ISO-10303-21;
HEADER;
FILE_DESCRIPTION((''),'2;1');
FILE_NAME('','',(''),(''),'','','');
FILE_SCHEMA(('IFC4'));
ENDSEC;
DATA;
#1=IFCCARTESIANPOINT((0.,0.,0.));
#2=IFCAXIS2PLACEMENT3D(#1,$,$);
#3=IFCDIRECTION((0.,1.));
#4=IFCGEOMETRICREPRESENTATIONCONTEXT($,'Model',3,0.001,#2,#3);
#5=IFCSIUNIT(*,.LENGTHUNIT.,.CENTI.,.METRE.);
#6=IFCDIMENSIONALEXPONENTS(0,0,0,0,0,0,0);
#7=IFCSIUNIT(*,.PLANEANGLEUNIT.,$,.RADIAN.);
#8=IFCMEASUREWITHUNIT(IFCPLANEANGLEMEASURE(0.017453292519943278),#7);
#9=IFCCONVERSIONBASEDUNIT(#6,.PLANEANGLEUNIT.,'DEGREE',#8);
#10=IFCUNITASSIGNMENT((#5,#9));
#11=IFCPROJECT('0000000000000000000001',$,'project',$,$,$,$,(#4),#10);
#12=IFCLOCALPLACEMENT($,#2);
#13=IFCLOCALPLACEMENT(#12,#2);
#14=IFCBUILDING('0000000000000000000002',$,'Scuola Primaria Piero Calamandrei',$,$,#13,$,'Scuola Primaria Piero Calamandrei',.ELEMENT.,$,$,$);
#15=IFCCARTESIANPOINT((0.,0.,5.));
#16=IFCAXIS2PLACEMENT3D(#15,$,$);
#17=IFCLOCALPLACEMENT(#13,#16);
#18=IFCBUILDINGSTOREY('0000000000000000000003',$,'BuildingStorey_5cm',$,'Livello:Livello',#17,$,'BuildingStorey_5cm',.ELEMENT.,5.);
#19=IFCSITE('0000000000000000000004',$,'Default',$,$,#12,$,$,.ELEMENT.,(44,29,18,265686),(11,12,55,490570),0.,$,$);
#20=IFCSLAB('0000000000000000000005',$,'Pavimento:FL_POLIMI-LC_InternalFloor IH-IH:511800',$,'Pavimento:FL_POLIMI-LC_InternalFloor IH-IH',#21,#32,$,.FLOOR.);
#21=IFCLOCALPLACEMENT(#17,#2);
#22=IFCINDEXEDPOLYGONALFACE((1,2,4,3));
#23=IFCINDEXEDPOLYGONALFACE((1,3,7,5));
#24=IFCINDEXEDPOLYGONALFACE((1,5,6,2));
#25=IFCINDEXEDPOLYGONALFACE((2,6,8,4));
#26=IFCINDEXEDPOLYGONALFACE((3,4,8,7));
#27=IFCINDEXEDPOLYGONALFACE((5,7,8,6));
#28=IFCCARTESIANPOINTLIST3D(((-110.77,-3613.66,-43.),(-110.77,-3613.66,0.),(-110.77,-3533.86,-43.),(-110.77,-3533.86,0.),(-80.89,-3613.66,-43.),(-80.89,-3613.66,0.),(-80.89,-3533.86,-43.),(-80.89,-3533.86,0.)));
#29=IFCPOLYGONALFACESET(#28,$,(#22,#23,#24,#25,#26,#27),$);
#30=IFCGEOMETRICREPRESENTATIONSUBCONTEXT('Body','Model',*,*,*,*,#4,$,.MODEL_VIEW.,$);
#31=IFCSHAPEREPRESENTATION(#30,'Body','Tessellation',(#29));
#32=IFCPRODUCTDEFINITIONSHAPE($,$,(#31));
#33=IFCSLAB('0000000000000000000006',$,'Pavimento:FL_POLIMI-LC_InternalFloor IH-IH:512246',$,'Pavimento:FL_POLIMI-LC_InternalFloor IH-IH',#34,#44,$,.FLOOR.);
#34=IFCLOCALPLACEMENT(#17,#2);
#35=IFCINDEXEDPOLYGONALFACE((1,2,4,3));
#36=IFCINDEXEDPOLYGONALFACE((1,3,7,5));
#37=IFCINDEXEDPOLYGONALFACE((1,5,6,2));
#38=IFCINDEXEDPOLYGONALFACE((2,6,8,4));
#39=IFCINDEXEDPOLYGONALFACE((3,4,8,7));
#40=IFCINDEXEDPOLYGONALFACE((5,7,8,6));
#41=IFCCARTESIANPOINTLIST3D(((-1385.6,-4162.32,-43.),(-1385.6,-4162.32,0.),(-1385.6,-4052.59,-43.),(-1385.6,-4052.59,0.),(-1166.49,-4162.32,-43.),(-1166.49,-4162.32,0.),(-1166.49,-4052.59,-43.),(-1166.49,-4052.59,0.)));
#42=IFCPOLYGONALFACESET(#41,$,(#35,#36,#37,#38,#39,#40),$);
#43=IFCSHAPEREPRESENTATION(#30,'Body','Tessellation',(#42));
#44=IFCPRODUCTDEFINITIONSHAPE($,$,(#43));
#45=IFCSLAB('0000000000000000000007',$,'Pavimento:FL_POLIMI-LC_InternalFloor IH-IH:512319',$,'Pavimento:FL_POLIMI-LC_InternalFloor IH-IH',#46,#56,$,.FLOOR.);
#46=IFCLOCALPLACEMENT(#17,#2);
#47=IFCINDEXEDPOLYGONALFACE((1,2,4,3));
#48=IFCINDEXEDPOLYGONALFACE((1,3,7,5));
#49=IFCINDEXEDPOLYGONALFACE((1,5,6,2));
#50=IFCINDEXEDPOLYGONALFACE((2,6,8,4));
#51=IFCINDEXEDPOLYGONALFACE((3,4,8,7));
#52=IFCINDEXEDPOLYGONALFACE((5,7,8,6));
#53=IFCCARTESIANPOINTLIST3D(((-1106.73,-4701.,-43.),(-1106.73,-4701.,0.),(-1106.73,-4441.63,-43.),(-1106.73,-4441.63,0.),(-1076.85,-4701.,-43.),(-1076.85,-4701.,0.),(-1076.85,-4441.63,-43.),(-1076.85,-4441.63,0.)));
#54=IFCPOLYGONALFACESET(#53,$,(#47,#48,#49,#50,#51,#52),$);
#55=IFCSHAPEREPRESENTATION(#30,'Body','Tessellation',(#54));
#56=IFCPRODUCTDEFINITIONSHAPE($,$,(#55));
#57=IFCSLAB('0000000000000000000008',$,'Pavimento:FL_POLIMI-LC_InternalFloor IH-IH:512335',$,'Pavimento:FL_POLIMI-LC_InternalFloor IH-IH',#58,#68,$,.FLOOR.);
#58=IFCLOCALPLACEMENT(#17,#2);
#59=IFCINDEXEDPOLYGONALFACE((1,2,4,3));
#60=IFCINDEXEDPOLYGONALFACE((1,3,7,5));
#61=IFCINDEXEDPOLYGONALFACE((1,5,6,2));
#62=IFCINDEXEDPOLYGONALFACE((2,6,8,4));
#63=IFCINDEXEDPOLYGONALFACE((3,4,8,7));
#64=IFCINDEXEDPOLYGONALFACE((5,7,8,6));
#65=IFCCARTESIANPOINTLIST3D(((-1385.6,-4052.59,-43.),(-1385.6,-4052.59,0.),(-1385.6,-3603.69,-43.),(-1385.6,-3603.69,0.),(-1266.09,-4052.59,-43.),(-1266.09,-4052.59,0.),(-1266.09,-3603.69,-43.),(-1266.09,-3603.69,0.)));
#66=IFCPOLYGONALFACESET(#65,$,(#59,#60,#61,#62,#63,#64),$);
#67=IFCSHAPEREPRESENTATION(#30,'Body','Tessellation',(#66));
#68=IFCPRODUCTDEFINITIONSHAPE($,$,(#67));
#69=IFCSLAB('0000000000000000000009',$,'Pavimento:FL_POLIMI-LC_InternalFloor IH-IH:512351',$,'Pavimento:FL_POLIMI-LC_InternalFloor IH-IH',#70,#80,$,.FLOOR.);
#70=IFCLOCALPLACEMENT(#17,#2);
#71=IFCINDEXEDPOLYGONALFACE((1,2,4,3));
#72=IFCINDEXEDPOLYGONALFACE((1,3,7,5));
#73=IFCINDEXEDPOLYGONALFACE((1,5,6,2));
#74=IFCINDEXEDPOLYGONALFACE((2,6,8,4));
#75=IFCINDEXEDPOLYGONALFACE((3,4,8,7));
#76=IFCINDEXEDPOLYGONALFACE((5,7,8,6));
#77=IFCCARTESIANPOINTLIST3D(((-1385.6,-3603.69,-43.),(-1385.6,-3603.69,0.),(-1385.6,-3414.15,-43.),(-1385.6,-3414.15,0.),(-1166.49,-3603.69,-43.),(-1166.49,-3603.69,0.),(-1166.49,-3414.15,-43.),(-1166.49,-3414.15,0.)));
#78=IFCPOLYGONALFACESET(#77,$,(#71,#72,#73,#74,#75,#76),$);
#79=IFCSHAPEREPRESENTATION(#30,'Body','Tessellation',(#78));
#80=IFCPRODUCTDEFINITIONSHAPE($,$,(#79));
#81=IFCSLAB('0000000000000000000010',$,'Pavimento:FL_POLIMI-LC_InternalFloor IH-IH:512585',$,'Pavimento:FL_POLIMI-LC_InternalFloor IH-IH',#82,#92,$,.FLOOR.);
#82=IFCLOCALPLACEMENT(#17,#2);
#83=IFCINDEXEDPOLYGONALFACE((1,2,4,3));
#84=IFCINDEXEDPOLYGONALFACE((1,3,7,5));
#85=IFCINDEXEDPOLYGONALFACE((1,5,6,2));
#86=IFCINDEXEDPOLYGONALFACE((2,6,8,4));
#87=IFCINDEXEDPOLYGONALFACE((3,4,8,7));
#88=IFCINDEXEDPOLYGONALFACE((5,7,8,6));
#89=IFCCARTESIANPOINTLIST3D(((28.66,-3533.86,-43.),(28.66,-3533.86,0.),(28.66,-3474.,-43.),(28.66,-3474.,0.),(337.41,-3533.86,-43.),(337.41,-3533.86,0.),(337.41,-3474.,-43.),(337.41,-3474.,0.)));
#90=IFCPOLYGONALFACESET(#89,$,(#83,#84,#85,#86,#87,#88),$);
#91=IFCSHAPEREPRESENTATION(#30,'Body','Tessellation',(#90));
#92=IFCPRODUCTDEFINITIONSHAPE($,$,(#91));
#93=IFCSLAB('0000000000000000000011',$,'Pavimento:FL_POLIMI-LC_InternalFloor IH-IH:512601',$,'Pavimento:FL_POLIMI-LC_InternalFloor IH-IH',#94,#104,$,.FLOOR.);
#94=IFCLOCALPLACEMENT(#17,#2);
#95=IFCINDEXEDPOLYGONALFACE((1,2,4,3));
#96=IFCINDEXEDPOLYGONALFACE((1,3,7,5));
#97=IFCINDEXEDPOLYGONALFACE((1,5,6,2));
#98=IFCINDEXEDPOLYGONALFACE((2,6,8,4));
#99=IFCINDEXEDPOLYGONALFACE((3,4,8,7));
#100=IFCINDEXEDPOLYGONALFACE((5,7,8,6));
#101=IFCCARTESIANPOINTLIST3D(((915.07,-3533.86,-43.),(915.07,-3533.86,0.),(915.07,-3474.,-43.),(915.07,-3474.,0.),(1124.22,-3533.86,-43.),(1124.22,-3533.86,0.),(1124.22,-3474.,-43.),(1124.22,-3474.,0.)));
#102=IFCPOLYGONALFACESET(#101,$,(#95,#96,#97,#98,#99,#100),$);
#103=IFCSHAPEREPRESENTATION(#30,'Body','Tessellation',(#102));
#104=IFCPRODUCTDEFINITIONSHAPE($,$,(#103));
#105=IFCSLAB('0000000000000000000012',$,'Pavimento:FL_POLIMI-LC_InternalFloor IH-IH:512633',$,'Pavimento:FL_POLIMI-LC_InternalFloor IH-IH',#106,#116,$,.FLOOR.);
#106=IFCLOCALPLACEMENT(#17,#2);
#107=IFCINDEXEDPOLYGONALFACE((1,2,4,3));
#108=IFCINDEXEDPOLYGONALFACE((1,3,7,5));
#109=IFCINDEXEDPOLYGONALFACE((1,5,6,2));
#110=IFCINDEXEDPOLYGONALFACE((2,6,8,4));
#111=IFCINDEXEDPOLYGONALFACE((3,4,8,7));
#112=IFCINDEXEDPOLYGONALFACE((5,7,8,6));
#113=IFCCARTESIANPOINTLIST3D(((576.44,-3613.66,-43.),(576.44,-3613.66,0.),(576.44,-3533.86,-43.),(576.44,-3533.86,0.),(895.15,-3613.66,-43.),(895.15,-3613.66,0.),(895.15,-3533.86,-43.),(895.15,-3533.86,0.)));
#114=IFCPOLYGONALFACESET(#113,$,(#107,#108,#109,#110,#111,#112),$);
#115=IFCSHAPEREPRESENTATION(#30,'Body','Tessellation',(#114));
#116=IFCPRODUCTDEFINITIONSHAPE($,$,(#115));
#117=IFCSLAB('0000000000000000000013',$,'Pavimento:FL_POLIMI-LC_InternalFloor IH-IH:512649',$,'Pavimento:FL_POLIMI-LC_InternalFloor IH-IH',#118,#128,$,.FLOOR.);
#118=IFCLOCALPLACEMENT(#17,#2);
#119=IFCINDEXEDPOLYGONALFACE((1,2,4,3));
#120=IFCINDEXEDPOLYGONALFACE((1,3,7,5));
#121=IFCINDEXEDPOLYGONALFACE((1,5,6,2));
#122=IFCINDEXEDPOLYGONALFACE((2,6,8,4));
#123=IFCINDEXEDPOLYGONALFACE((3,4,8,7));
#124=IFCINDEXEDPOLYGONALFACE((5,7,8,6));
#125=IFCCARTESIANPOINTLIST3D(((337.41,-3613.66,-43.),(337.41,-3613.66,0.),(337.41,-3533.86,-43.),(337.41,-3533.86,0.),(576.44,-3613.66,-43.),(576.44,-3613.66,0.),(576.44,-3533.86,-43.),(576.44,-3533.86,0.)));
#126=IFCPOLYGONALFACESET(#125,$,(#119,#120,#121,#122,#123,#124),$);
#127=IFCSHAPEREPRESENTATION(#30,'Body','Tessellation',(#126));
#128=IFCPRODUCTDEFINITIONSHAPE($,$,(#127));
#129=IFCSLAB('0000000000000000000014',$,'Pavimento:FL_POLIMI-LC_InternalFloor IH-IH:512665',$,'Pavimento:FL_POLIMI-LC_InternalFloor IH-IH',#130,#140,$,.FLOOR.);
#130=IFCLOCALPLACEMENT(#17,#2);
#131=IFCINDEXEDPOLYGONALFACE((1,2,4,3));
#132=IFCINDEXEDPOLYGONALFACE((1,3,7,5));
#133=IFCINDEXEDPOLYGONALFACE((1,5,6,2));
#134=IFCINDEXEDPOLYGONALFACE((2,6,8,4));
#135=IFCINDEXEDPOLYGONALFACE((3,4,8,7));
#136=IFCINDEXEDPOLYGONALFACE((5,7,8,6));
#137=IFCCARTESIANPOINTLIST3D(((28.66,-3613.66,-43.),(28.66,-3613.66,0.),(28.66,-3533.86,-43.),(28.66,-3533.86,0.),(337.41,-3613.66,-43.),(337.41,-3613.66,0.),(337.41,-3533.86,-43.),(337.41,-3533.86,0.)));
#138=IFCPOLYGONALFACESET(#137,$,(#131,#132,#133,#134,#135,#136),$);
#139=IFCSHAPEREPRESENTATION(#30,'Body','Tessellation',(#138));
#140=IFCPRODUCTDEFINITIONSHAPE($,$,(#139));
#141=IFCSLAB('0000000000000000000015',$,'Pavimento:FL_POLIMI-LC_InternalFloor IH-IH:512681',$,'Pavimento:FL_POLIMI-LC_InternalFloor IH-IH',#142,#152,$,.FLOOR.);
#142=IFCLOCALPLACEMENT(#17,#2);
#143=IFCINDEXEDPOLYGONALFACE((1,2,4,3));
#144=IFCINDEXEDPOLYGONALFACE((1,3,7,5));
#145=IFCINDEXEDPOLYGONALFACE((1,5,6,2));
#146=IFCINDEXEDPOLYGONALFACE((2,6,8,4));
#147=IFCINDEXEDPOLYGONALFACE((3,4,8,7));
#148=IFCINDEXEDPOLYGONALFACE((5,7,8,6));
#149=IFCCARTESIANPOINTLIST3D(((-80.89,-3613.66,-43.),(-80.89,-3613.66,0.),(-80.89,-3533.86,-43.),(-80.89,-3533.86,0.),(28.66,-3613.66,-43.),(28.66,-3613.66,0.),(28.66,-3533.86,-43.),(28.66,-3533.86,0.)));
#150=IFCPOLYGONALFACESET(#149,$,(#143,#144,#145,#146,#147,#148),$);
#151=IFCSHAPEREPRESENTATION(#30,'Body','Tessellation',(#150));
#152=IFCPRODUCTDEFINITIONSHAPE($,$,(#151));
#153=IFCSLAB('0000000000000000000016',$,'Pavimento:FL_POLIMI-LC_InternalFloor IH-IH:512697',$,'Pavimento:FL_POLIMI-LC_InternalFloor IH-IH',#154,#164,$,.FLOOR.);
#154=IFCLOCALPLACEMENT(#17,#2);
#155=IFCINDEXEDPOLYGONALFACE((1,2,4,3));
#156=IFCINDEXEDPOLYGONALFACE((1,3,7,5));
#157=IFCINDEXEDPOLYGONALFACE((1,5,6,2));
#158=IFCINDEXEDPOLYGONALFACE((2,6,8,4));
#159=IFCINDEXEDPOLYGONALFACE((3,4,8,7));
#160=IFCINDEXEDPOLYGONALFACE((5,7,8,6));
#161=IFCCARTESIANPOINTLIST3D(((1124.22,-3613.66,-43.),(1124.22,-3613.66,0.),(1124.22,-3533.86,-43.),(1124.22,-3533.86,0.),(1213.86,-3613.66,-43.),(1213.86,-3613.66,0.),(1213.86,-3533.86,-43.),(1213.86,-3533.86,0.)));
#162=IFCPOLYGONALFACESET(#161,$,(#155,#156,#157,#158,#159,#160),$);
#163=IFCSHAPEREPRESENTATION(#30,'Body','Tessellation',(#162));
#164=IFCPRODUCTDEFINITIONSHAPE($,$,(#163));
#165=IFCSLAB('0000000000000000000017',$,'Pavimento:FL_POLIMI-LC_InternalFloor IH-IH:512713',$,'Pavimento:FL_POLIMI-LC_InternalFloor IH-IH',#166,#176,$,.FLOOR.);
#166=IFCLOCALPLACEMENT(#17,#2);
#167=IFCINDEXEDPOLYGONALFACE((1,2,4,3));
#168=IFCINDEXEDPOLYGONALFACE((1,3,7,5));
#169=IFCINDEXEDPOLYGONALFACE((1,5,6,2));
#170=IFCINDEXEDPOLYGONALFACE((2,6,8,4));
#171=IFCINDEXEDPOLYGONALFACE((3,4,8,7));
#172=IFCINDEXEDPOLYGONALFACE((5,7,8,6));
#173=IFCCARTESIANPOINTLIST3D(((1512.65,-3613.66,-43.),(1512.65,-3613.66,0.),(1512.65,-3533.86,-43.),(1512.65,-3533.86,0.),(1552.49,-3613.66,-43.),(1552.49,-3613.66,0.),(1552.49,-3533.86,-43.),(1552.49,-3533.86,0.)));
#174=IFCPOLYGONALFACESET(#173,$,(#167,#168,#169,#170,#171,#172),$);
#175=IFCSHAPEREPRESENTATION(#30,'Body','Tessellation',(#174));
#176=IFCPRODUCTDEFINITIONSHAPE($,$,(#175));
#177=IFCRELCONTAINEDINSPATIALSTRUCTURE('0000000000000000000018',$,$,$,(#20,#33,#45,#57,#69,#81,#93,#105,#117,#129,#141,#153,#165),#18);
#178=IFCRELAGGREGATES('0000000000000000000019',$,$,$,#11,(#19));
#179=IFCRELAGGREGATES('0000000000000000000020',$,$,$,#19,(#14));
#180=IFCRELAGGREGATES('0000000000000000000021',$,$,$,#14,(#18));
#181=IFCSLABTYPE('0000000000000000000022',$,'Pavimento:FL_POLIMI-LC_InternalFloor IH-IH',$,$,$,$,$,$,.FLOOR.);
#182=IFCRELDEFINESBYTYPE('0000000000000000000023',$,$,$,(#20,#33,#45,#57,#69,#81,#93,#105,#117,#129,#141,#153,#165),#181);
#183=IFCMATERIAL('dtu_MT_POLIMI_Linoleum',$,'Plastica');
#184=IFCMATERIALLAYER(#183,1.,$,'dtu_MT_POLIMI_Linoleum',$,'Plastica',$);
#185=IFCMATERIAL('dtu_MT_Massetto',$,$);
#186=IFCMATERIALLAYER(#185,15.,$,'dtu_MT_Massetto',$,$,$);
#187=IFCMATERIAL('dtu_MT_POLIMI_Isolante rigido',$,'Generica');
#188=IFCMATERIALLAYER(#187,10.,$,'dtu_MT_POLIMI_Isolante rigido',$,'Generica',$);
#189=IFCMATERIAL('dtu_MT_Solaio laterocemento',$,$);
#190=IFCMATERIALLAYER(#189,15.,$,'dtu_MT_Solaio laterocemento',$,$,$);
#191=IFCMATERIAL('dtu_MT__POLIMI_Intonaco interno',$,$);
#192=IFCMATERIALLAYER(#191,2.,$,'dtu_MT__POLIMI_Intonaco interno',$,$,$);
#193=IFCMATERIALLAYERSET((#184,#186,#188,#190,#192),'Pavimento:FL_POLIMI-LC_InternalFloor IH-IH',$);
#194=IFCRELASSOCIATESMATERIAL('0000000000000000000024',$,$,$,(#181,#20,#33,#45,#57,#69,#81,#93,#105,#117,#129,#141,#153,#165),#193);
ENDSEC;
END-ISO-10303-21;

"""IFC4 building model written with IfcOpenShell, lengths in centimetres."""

from ifc_helpers import new_model, entity, si_unit, converted_unit, direction, frame, frame_2d, origin, origin_2d_with_axis, place, context, subcontext, project, spatial, rectangle, extrude, material, layer, layer_set, layer_usage, type_object, element, save


model = new_model("IFC4")

# Units and contexts
model_context = context("Model", 3, precision=0.001, world=origin(), true_north=direction((0.0, 1.0)))
body_context = subcontext(model_context, "Body", "Model", "MODEL_VIEW")
ifc_project = project(units=[si_unit("LENGTHUNIT", "METRE", prefix="CENTI"), converted_unit("PLANEANGLEUNIT", "DEGREE", entity("IfcPlaneAngleMeasure", 0.017453292519943278), si_unit("PLANEANGLEUNIT", "RADIAN"), dimensions=[0, 0, 0, 0, 0, 0, 0])], contexts=[model_context])

# Site, building, storey
site_placement = place(None, origin())
site = spatial("IfcSite", under=ifc_project, at=site_placement, Name="Default", CompositionType="ELEMENT", RefLatitude=(44, 29, 18, 265686), RefLongitude=(11, 12, 55, 490570), RefElevation=0.0)
building_placement = place(site_placement, origin())
building = spatial("IfcBuilding", under=site, at=building_placement, Name="Scuola Primaria Piero Calamandrei", LongName="Scuola Primaria Piero Calamandrei", CompositionType="ELEMENT")
storey_placement = place(building_placement, frame((0.0, 0.0, 5.0)))
storey = spatial("IfcBuildingStorey", under=building, at=storey_placement, Name="BuildingStorey_5cm", ObjectType="Livello:Livello", LongName="BuildingStorey_5cm", CompositionType="ELEMENT", Elevation=5.0)

# Slabs
ifc_material_1 = material(Name="dtu_MT_POLIMI_Linoleum", Category="Plastica")
ifc_layer_1 = layer(ifc_material_1, 1.0, Name="dtu_MT_POLIMI_Linoleum", Category="Plastica")
ifc_material_2 = material(Name="dtu_MT_Massetto")
ifc_layer_2 = layer(ifc_material_2, 15.0, Name="dtu_MT_Massetto")
ifc_material_3 = material(Name="dtu_MT_POLIMI_Isolante rigido", Category="Generica")
ifc_layer_3 = layer(ifc_material_3, 10.0, Name="dtu_MT_POLIMI_Isolante rigido", Category="Generica")
ifc_material_4 = material(Name="dtu_MT_Solaio laterocemento")
ifc_layer_4 = layer(ifc_material_4, 15.0, Name="dtu_MT_Solaio laterocemento")
ifc_material_5 = material(Name="dtu_MT__POLIMI_Intonaco interno")
ifc_layer_5 = layer(ifc_material_5, 2.0, Name="dtu_MT__POLIMI_Intonaco interno")
ifc_layer_set_1 = layer_set([ifc_layer_1, ifc_layer_2, ifc_layer_3, ifc_layer_4, ifc_layer_5], Name="Pavimento:FL_POLIMI-LC_InternalFloor IH-IH")
ifc_layer_usage_1 = layer_usage(ifc_layer_set_1, "AXIS3", "POSITIVE", 0.0)
slab_type_1 = type_object("IfcSlabType", Name="Pavimento:FL_POLIMI-LC_InternalFloor IH-IH", PredefinedType="FLOOR", material=ifc_layer_set_1)
slab_1_placement = place(storey_placement, origin())
element("IfcSlab", 1, at=slab_1_placement, inside=storey, type_object=slab_type_1, material=ifc_layer_usage_1, Name="Pavimento:FL_POLIMI-LC_InternalFloor IH-IH:511800", ObjectType="Pavimento:FL_POLIMI-LC_InternalFloor IH-IH", PredefinedType="FLOOR", context=body_context, shape_type="SweptSolid", body=[
    extrude(rectangle(XDim=79.8, YDim=29.88, at=origin_2d_with_axis()), frame((-95.83, -3573.76, 0.0), z_axis=(0.0, 0.0, -1.0), x_axis=(0.0, 1.0, 0.0)), (0.0, 0.0, 1.0), 43.0),
])
ifc_layer_usage_2 = layer_usage(ifc_layer_set_1, "AXIS3", "POSITIVE", 0.0)
slab_2_placement = place(storey_placement, origin())
element("IfcSlab", 2, at=slab_2_placement, inside=storey, type_object=slab_type_1, material=ifc_layer_usage_2, Name="Pavimento:FL_POLIMI-LC_InternalFloor IH-IH:512246", ObjectType="Pavimento:FL_POLIMI-LC_InternalFloor IH-IH", PredefinedType="FLOOR", context=body_context, shape_type="SweptSolid", body=[
    extrude(rectangle(XDim=109.73, YDim=219.11, at=frame_2d((0.0, 0.0), x_axis=(1.0, 0.0))), frame((-1276.05, -4107.45, 0.0), z_axis=(0.0, 0.0, -1.0), x_axis=(0.0, 1.0, 0.0)), (0.0, 0.0, 1.0), 43.0),
])
ifc_layer_usage_3 = layer_usage(ifc_layer_set_1, "AXIS3", "POSITIVE", 0.0)
slab_3_placement = place(storey_placement, origin())
element("IfcSlab", 3, at=slab_3_placement, inside=storey, type_object=slab_type_1, material=ifc_layer_usage_3, Name="Pavimento:FL_POLIMI-LC_InternalFloor IH-IH:512319", ObjectType="Pavimento:FL_POLIMI-LC_InternalFloor IH-IH", PredefinedType="FLOOR", context=body_context, shape_type="SweptSolid", body=[
    extrude(rectangle(XDim=259.36, YDim=29.88, at=frame_2d((0.0, 0.0), x_axis=(1.0, 0.0))), frame((-1091.79, -4571.31, 0.0), z_axis=(0.0, 0.0, -1.0), x_axis=(0.0, 1.0, 0.0)), (0.0, 0.0, 1.0), 43.0),
])
ifc_layer_usage_4 = layer_usage(ifc_layer_set_1, "AXIS3", "POSITIVE", 0.0)
slab_4_placement = place(storey_placement, origin())
element("IfcSlab", 4, at=slab_4_placement, inside=storey, type_object=slab_type_1, material=ifc_layer_usage_4, Name="Pavimento:FL_POLIMI-LC_InternalFloor IH-IH:512335", ObjectType="Pavimento:FL_POLIMI-LC_InternalFloor IH-IH", PredefinedType="FLOOR", context=body_context, shape_type="SweptSolid", body=[
    extrude(rectangle(XDim=448.9, YDim=119.52, at=frame_2d((0.0, 0.0), x_axis=(1.0, 0.0))), frame((-1325.84, -3828.14, 0.0), z_axis=(0.0, 0.0, -1.0), x_axis=(0.0, 1.0, 0.0)), (0.0, 0.0, 1.0), 43.0),
])
ifc_layer_usage_5 = layer_usage(ifc_layer_set_1, "AXIS3", "POSITIVE", 0.0)
slab_5_placement = place(storey_placement, origin())
element("IfcSlab", 5, at=slab_5_placement, inside=storey, type_object=slab_type_1, material=ifc_layer_usage_5, Name="Pavimento:FL_POLIMI-LC_InternalFloor IH-IH:512351", ObjectType="Pavimento:FL_POLIMI-LC_InternalFloor IH-IH", PredefinedType="FLOOR", context=body_context, shape_type="SweptSolid", body=[
    extrude(rectangle(XDim=189.54, YDim=219.11, at=frame_2d((0.0, 0.0), x_axis=(1.0, 0.0))), frame((-1276.05, -3508.92, 0.0), z_axis=(0.0, 0.0, -1.0), x_axis=(0.0, 1.0, 0.0)), (0.0, 0.0, 1.0), 43.0),
])
ifc_layer_usage_6 = layer_usage(ifc_layer_set_1, "AXIS3", "POSITIVE", 0.0)
slab_6_placement = place(storey_placement, origin())
element("IfcSlab", 6, at=slab_6_placement, inside=storey, type_object=slab_type_1, material=ifc_layer_usage_6, Name="Pavimento:FL_POLIMI-LC_InternalFloor IH-IH:512585", ObjectType="Pavimento:FL_POLIMI-LC_InternalFloor IH-IH", PredefinedType="FLOOR", context=body_context, shape_type="SweptSolid", body=[
    extrude(rectangle(XDim=59.85, YDim=308.75, at=frame_2d((0.0, 0.0), x_axis=(1.0, 0.0))), frame((183.04, -3503.93, 0.0), z_axis=(0.0, 0.0, -1.0), x_axis=(0.0, 1.0, 0.0)), (0.0, 0.0, 1.0), 43.0),
])
ifc_layer_usage_7 = layer_usage(ifc_layer_set_1, "AXIS3", "POSITIVE", 0.0)
slab_7_placement = place(storey_placement, origin())
element("IfcSlab", 7, at=slab_7_placement, inside=storey, type_object=slab_type_1, material=ifc_layer_usage_7, Name="Pavimento:FL_POLIMI-LC_InternalFloor IH-IH:512601", ObjectType="Pavimento:FL_POLIMI-LC_InternalFloor IH-IH", PredefinedType="FLOOR", context=body_context, shape_type="SweptSolid", body=[
    extrude(rectangle(XDim=59.85, YDim=209.15, at=frame_2d((0.0, 0.0), x_axis=(1.0, 0.0))), frame((1019.65, -3503.93, 0.0), z_axis=(0.0, 0.0, -1.0), x_axis=(0.0, 1.0, 0.0)), (0.0, 0.0, 1.0), 43.0),
])
ifc_layer_usage_8 = layer_usage(ifc_layer_set_1, "AXIS3", "POSITIVE", 0.0)
slab_8_placement = place(storey_placement, origin())
element("IfcSlab", 8, at=slab_8_placement, inside=storey, type_object=slab_type_1, material=ifc_layer_usage_8, Name="Pavimento:FL_POLIMI-LC_InternalFloor IH-IH:512633", ObjectType="Pavimento:FL_POLIMI-LC_InternalFloor IH-IH", PredefinedType="FLOOR", context=body_context, shape_type="SweptSolid", body=[
    extrude(rectangle(XDim=79.8, YDim=318.71, at=origin_2d_with_axis()), frame((735.8, -3573.76, 0.0), z_axis=(0.0, 0.0, -1.0), x_axis=(0.0, 1.0, 0.0)), (0.0, 0.0, 1.0), 43.0),
])
ifc_layer_usage_9 = layer_usage(ifc_layer_set_1, "AXIS3", "POSITIVE", 0.0)
slab_9_placement = place(storey_placement, origin())
element("IfcSlab", 9, at=slab_9_placement, inside=storey, type_object=slab_type_1, material=ifc_layer_usage_9, Name="Pavimento:FL_POLIMI-LC_InternalFloor IH-IH:512649", ObjectType="Pavimento:FL_POLIMI-LC_InternalFloor IH-IH", PredefinedType="FLOOR", context=body_context, shape_type="SweptSolid", body=[
    extrude(rectangle(XDim=79.8, YDim=239.03, at=frame_2d((0.0, 0.0), x_axis=(1.0, 0.0))), frame((456.93, -3573.76, 0.0), z_axis=(0.0, 0.0, -1.0), x_axis=(0.0, 1.0, 0.0)), (0.0, 0.0, 1.0), 43.0),
])
ifc_layer_usage_10 = layer_usage(ifc_layer_set_1, "AXIS3", "POSITIVE", 0.0)
slab_10_placement = place(storey_placement, origin())
element("IfcSlab", 10, at=slab_10_placement, inside=storey, type_object=slab_type_1, material=ifc_layer_usage_10, Name="Pavimento:FL_POLIMI-LC_InternalFloor IH-IH:512665", ObjectType="Pavimento:FL_POLIMI-LC_InternalFloor IH-IH", PredefinedType="FLOOR", context=body_context, shape_type="SweptSolid", body=[
    extrude(rectangle(XDim=79.8, YDim=308.75, at=origin_2d_with_axis()), frame((183.04, -3573.76, 0.0), z_axis=(0.0, 0.0, -1.0), x_axis=(0.0, 1.0, 0.0)), (0.0, 0.0, 1.0), 43.0),
])
ifc_layer_usage_11 = layer_usage(ifc_layer_set_1, "AXIS3", "POSITIVE", 0.0)
slab_11_placement = place(storey_placement, origin())
element("IfcSlab", 11, at=slab_11_placement, inside=storey, type_object=slab_type_1, material=ifc_layer_usage_11, Name="Pavimento:FL_POLIMI-LC_InternalFloor IH-IH:512681", ObjectType="Pavimento:FL_POLIMI-LC_InternalFloor IH-IH", PredefinedType="FLOOR", context=body_context, shape_type="SweptSolid", body=[
    extrude(rectangle(XDim=79.8, YDim=109.56, at=origin_2d_with_axis()), frame((-26.11, -3573.76, 0.0), z_axis=(0.0, 0.0, -1.0), x_axis=(0.0, 1.0, 0.0)), (0.0, 0.0, 1.0), 43.0),
])
ifc_layer_usage_12 = layer_usage(ifc_layer_set_1, "AXIS3", "POSITIVE", 0.0)
slab_12_placement = place(storey_placement, origin())
element("IfcSlab", 12, at=slab_12_placement, inside=storey, type_object=slab_type_1, material=ifc_layer_usage_12, Name="Pavimento:FL_POLIMI-LC_InternalFloor IH-IH:512697", ObjectType="Pavimento:FL_POLIMI-LC_InternalFloor IH-IH", PredefinedType="FLOOR", context=body_context, shape_type="SweptSolid", body=[
    extrude(rectangle(XDim=79.8, YDim=89.64, at=frame_2d((0.0, 0.0), x_axis=(1.0, 0.0))), frame((1169.04, -3573.76, 0.0), z_axis=(0.0, 0.0, -1.0), x_axis=(0.0, 1.0, 0.0)), (0.0, 0.0, 1.0), 43.0),
])
ifc_layer_usage_13 = layer_usage(ifc_layer_set_1, "AXIS3", "POSITIVE", 0.0)
slab_13_placement = place(storey_placement, origin())
element("IfcSlab", 13, at=slab_13_placement, inside=storey, type_object=slab_type_1, material=ifc_layer_usage_13, Name="Pavimento:FL_POLIMI-LC_InternalFloor IH-IH:512713", ObjectType="Pavimento:FL_POLIMI-LC_InternalFloor IH-IH", PredefinedType="FLOOR", context=body_context, shape_type="SweptSolid", body=[
    extrude(rectangle(XDim=79.8, YDim=39.84, at=frame_2d((0.0, 0.0), x_axis=(1.0, 0.0))), frame((1532.57, -3573.76, 0.0), z_axis=(0.0, 0.0, -1.0), x_axis=(0.0, 1.0, 0.0)), (0.0, 0.0, 1.0), 43.0),
])

save(model, "model.ifc")
